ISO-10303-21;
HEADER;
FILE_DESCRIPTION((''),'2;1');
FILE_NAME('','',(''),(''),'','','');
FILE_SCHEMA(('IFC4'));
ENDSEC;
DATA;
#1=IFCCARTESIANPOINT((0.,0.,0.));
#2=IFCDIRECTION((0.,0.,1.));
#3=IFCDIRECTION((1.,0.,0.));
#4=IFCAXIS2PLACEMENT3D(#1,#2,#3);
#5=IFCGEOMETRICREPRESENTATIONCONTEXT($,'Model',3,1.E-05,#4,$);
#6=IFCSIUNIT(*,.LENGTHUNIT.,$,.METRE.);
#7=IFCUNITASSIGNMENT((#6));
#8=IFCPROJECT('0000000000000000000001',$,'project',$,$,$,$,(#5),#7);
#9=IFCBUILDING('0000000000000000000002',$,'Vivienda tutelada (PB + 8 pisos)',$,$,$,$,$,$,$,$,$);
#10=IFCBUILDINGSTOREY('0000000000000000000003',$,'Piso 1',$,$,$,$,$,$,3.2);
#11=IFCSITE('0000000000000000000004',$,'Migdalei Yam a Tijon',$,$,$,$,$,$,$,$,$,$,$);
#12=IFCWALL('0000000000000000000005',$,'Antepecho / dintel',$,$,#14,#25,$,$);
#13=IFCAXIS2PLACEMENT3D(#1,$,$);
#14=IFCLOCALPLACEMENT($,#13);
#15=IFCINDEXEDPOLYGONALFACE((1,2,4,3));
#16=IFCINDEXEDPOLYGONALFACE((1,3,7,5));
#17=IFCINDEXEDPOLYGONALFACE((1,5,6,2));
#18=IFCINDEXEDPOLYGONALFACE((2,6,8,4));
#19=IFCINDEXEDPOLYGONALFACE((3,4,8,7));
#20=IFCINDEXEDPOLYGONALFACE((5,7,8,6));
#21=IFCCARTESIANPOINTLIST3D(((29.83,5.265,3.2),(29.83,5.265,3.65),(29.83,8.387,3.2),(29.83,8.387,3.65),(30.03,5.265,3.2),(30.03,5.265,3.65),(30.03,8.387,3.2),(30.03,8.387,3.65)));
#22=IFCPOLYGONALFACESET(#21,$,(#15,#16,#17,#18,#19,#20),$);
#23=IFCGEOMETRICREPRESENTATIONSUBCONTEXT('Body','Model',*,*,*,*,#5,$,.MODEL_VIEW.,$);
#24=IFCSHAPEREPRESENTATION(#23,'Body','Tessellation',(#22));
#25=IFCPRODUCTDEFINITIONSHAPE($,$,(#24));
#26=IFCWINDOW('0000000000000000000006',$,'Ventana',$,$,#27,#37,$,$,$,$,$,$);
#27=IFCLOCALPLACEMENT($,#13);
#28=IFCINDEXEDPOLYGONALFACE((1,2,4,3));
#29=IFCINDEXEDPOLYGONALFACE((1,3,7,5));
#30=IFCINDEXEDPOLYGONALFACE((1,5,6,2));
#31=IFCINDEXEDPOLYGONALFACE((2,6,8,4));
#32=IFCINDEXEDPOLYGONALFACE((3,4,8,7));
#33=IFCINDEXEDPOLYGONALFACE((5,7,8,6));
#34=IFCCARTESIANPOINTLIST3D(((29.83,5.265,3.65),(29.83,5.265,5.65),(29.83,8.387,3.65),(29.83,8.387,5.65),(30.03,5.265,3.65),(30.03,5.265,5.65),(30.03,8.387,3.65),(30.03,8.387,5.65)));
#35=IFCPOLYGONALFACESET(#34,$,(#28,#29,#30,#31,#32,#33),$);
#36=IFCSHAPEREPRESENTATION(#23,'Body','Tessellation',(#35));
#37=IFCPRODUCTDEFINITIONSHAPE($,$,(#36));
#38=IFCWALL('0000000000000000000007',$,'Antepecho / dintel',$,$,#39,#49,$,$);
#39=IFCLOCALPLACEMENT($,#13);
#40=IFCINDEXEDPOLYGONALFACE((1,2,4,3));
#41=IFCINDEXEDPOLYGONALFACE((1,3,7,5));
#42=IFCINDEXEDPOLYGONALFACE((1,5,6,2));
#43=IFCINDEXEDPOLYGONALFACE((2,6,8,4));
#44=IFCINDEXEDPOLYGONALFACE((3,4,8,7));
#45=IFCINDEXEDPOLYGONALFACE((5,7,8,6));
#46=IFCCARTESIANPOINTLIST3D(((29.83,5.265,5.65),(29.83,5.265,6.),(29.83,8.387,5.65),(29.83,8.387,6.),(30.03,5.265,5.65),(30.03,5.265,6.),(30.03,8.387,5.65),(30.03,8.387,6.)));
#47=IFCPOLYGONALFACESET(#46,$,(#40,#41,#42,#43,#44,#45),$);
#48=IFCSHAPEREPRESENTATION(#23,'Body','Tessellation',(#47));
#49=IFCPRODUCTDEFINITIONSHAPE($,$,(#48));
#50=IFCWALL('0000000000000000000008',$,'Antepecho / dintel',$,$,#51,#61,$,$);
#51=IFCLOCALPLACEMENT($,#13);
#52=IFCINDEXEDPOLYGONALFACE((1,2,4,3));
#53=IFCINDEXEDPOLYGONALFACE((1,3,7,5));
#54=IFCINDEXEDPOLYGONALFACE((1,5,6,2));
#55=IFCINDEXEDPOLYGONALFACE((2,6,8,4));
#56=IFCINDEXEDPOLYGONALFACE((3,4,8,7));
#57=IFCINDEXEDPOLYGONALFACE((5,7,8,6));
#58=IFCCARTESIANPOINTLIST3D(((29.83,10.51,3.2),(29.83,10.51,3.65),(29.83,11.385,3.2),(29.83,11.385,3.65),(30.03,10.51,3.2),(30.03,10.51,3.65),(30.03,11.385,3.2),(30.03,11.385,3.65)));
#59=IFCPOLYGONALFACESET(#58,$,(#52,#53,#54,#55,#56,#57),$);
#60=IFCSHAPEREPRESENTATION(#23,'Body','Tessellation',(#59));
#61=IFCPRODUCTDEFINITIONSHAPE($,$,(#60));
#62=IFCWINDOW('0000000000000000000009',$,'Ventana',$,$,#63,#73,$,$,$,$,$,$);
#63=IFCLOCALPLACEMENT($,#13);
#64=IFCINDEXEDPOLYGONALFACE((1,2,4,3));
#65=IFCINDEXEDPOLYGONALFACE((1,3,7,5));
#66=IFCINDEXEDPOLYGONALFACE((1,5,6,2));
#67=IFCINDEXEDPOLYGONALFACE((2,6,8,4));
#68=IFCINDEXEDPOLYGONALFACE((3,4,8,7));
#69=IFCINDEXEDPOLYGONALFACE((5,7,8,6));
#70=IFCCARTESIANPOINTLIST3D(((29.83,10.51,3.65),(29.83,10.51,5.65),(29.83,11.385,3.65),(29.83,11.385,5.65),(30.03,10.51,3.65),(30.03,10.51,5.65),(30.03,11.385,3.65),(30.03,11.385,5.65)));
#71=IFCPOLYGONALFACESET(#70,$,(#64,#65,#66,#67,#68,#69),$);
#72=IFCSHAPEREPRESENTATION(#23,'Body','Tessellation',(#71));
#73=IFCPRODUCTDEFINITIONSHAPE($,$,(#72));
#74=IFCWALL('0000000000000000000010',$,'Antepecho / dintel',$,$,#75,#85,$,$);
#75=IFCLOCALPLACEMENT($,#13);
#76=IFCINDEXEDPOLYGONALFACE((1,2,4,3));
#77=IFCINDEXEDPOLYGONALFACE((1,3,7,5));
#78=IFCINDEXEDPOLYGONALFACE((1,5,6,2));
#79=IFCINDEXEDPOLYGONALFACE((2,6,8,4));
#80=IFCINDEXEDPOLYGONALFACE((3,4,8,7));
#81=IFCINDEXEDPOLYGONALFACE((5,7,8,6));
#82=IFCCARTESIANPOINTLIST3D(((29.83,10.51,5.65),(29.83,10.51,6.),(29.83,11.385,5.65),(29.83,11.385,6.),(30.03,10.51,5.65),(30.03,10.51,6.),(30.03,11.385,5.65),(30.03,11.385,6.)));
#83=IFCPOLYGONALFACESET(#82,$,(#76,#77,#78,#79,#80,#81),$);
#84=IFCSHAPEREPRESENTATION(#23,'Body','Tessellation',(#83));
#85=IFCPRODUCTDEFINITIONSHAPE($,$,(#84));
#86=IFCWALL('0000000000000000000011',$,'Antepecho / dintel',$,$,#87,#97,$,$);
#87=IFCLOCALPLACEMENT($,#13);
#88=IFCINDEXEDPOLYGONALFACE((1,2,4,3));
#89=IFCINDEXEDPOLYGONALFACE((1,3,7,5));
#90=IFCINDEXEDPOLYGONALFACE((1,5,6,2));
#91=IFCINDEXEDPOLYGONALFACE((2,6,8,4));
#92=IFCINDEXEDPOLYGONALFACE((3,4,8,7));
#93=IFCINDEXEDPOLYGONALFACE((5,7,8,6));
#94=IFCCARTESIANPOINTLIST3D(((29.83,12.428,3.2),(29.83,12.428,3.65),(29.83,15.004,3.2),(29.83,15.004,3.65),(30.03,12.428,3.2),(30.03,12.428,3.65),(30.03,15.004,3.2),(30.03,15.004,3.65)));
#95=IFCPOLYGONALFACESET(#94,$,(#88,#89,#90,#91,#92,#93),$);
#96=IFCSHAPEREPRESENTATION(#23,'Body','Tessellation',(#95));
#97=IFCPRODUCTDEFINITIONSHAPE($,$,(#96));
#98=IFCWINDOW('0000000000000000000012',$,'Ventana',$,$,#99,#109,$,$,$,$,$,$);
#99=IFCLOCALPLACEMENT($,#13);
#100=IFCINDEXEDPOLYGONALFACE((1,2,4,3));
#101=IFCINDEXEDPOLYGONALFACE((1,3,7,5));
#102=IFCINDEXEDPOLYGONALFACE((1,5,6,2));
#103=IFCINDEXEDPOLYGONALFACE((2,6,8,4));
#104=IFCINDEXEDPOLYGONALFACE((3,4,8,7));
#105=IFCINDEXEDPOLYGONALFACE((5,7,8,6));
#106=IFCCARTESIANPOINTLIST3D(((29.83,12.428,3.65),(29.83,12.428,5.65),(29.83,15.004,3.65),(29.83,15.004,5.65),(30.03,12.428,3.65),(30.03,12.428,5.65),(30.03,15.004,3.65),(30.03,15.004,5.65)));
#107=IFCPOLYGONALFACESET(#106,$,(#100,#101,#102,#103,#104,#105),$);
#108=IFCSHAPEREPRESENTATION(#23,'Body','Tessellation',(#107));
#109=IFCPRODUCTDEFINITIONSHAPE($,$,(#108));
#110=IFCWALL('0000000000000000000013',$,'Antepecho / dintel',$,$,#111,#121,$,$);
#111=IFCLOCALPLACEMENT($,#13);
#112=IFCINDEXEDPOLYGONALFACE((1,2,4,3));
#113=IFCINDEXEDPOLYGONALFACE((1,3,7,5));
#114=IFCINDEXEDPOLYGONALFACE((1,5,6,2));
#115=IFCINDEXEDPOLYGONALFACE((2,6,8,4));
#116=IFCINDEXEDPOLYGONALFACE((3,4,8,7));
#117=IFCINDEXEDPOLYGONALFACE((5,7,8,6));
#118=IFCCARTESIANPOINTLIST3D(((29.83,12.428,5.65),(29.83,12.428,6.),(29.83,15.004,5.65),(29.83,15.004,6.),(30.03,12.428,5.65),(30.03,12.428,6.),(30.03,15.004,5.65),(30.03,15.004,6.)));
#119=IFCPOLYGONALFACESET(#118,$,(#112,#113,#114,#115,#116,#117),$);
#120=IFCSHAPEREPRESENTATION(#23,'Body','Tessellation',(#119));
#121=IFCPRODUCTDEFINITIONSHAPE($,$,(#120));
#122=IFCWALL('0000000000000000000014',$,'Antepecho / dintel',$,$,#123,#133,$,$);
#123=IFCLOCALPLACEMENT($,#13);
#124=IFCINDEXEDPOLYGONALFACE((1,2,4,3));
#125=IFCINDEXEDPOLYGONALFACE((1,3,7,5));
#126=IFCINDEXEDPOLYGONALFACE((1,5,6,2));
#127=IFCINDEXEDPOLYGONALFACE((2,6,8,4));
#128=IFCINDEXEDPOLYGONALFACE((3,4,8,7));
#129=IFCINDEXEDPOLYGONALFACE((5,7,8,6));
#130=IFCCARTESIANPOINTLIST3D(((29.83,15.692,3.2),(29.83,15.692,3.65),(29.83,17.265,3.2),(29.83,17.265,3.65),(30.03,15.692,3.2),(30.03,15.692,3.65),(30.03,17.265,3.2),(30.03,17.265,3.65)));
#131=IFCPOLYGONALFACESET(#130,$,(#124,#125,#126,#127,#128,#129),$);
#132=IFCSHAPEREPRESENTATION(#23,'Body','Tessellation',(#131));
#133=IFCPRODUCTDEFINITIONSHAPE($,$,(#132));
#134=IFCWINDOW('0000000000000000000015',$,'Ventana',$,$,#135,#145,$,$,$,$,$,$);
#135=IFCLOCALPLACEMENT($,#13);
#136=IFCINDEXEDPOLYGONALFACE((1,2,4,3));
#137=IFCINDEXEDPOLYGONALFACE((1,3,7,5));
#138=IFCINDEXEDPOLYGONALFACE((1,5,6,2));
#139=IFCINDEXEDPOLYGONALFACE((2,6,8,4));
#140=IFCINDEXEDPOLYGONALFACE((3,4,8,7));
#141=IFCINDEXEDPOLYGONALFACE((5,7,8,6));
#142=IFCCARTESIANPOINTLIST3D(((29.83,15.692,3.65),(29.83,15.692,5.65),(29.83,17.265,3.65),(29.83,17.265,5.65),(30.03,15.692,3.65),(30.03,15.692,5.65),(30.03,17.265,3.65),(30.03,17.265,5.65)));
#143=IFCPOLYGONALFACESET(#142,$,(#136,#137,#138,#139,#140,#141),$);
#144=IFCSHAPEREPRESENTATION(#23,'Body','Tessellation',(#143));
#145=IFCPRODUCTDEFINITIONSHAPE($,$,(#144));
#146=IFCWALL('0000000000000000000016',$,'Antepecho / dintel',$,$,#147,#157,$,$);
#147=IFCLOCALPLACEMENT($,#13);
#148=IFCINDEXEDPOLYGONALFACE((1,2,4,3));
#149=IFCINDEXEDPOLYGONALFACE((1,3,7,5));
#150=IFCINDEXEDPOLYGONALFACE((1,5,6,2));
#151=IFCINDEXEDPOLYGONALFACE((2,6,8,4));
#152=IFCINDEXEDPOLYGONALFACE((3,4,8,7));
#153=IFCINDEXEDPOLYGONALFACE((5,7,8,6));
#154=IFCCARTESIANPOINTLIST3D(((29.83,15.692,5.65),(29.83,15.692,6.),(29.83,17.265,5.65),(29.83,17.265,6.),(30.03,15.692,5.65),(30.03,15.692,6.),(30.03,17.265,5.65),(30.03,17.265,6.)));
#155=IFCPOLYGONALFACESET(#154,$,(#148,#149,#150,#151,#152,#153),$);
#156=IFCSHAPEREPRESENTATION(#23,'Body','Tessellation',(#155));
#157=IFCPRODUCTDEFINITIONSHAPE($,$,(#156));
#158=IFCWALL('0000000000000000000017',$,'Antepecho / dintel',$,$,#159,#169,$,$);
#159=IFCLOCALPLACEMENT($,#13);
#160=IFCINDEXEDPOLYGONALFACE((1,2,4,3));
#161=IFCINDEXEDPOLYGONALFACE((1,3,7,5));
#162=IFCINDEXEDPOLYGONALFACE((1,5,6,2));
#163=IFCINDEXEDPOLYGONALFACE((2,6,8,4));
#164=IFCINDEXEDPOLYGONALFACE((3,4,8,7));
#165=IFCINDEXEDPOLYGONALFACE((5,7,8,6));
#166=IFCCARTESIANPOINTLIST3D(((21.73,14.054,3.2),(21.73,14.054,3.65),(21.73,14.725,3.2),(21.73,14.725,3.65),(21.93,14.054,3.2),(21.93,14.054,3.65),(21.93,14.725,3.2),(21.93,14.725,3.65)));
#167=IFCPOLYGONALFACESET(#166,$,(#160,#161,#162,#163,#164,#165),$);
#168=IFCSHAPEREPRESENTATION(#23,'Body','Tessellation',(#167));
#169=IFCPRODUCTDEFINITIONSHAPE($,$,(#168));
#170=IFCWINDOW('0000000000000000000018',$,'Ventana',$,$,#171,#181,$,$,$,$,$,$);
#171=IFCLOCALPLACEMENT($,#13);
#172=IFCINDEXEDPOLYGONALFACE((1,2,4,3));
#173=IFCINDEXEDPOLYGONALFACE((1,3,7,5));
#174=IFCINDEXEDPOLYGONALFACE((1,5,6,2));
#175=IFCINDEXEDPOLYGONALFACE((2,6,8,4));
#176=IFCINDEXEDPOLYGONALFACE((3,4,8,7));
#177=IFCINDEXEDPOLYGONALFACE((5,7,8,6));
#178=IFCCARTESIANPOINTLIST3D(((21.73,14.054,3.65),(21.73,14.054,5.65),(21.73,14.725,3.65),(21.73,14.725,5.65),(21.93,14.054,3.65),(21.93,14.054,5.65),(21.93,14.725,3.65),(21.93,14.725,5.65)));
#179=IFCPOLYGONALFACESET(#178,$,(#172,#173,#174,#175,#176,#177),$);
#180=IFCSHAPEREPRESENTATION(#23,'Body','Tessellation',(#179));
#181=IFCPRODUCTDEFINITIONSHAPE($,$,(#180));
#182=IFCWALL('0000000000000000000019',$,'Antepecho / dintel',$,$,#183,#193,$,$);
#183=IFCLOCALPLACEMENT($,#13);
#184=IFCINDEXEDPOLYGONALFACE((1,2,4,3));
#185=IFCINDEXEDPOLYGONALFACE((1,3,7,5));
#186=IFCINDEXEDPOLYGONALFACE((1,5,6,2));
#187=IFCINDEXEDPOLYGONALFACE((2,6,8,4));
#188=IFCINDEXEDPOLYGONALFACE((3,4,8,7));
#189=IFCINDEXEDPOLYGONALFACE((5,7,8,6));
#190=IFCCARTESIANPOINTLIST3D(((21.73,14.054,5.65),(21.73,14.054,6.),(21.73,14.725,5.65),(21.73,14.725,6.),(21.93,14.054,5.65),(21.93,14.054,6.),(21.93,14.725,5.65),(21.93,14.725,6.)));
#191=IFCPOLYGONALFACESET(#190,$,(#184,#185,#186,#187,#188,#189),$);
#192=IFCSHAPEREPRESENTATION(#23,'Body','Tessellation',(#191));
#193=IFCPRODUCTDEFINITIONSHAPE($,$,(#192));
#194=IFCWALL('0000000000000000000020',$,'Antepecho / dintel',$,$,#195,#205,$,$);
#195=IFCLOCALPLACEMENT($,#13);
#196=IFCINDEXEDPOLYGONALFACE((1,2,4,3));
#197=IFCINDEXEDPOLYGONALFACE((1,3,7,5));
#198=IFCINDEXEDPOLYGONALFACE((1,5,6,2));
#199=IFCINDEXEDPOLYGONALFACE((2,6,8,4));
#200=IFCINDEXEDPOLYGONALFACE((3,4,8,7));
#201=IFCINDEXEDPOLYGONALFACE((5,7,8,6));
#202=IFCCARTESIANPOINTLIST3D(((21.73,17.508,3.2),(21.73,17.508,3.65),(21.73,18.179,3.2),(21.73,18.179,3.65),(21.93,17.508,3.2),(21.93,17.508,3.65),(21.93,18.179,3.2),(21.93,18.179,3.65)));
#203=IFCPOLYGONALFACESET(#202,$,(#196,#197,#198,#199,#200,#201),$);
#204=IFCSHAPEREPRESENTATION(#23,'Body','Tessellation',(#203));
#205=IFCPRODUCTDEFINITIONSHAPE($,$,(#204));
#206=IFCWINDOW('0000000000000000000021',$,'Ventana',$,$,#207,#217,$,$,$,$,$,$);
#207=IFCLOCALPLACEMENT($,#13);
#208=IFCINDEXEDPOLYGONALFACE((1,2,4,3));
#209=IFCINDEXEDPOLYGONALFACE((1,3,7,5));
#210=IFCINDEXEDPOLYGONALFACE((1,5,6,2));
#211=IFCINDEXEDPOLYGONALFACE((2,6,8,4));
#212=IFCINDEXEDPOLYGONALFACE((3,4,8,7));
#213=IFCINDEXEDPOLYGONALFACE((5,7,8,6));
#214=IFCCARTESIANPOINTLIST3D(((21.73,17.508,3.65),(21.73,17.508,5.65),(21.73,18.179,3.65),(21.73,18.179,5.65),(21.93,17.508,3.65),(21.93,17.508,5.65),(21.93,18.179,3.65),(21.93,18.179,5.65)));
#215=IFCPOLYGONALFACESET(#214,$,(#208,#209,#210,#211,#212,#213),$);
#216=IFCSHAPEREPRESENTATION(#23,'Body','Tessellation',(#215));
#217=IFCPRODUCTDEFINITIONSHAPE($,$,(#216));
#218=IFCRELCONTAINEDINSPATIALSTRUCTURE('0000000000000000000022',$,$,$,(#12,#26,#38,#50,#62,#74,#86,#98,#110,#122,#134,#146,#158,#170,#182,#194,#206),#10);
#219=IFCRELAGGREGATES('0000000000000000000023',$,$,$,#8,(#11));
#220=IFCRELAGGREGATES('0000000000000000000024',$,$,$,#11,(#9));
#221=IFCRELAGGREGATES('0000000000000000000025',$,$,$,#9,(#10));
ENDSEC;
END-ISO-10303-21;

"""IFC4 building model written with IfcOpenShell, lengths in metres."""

from ifc_helpers import new_model, si_unit, frame, origin_with_axes, context, subcontext, project, spatial, line, indexed_curve, outline, extrude, element, save


model = new_model("IFC4")

# Units and contexts
model_context = context("Model", 3, precision=1e-05, world=origin_with_axes())
body_context = subcontext(model_context, "Body", "Model", "MODEL_VIEW")
ifc_project = project(units=[si_unit("LENGTHUNIT", "METRE")], contexts=[model_context])

# Site, building, storey
site = spatial("IfcSite", under=ifc_project, Name="Migdalei Yam a Tijon")
building = spatial("IfcBuilding", under=site, Name="Vivienda tutelada (PB + 8 pisos)")
storey = spatial("IfcBuildingStorey", under=building, Name="Piso 1", Elevation=3.2)

# Wall
element("IfcWall", 1, inside=storey, Name="Antepecho / dintel", context=body_context, shape_type="SweptSolid", body=[
    extrude(outline(indexed_curve([(0.0, 0.0), (0.2, 0.0), (0.2, 3.122), (0.0, 3.122)], segments=[line(1, 2, 3, 4, 1)])), frame((29.83, 5.265, 3.2), z_axis=(0.0, 0.0, 1.0), x_axis=(1.0, 0.0, 0.0)), (0.0, 0.0, 1.0), 0.45),
])

# Window
element("IfcWindow", 2, inside=storey, Name="Ventana", context=body_context, shape_type="SweptSolid", body=[
    extrude(outline(indexed_curve([(0.0, 0.0), (0.2, 0.0), (0.2, 3.122), (0.0, 3.122)], segments=[line(1, 2, 3, 4, 1)])), frame((29.83, 5.265, 3.65), z_axis=(0.0, 0.0, 1.0), x_axis=(1.0, 0.0, 0.0)), (0.0, 0.0, 1.0), 2.0),
])

# Walls
element("IfcWall", 3, inside=storey, Name="Antepecho / dintel", context=body_context, shape_type="SweptSolid", body=[
    extrude(outline(indexed_curve([(0.0, 0.0), (0.2, 0.0), (0.2, 3.122), (0.0, 3.122)], segments=[line(1, 2, 3, 4, 1)])), frame((29.83, 5.265, 5.65), z_axis=(0.0, 0.0, 1.0), x_axis=(1.0, 0.0, 0.0)), (0.0, 0.0, 1.0), 0.35),
])
element("IfcWall", 4, inside=storey, Name="Antepecho / dintel", context=body_context, shape_type="SweptSolid", body=[
    extrude(outline(indexed_curve([(0.0, 0.0), (0.2, 0.0), (0.2, 0.875), (0.0, 0.875)], segments=[line(1, 2, 3, 4, 1)])), frame((29.83, 10.51, 3.2), z_axis=(0.0, 0.0, 1.0), x_axis=(1.0, 0.0, 0.0)), (0.0, 0.0, 1.0), 0.45),
])

# Window
element("IfcWindow", 5, inside=storey, Name="Ventana", context=body_context, shape_type="SweptSolid", body=[
    extrude(outline(indexed_curve([(0.0, 0.0), (0.2, 0.0), (0.2, 0.875), (0.0, 0.875)], segments=[line(1, 2, 3, 4, 1)])), frame((29.83, 10.51, 3.65), z_axis=(0.0, 0.0, 1.0), x_axis=(1.0, 0.0, 0.0)), (0.0, 0.0, 1.0), 2.0),
])

# Walls
element("IfcWall", 6, inside=storey, Name="Antepecho / dintel", context=body_context, shape_type="SweptSolid", body=[
    extrude(outline(indexed_curve([(0.0, 0.0), (0.2, 0.0), (0.2, 0.875), (0.0, 0.875)], segments=[line(1, 2, 3, 4, 1)])), frame((29.83, 10.51, 5.65), z_axis=(0.0, 0.0, 1.0), x_axis=(1.0, 0.0, 0.0)), (0.0, 0.0, 1.0), 0.35),
])
element("IfcWall", 7, inside=storey, Name="Antepecho / dintel", context=body_context, shape_type="SweptSolid", body=[
    extrude(outline(indexed_curve([(0.0, 0.0), (0.2, 0.0), (0.2, 2.576), (0.0, 2.576)], segments=[line(1, 2, 3, 4, 1)])), frame((29.83, 12.428, 3.2), z_axis=(0.0, 0.0, 1.0), x_axis=(1.0, 0.0, 0.0)), (0.0, 0.0, 1.0), 0.45),
])

# Window
element("IfcWindow", 8, inside=storey, Name="Ventana", context=body_context, shape_type="SweptSolid", body=[
    extrude(outline(indexed_curve([(0.0, 0.0), (0.2, 0.0), (0.2, 2.576), (0.0, 2.576)], segments=[line(1, 2, 3, 4, 1)])), frame((29.83, 12.428, 3.65), z_axis=(0.0, 0.0, 1.0), x_axis=(1.0, 0.0, 0.0)), (0.0, 0.0, 1.0), 2.0),
])

# Walls
element("IfcWall", 9, inside=storey, Name="Antepecho / dintel", context=body_context, shape_type="SweptSolid", body=[
    extrude(outline(indexed_curve([(0.0, 0.0), (0.2, 0.0), (0.2, 2.576), (0.0, 2.576)], segments=[line(1, 2, 3, 4, 1)])), frame((29.83, 12.428, 5.65), z_axis=(0.0, 0.0, 1.0), x_axis=(1.0, 0.0, 0.0)), (0.0, 0.0, 1.0), 0.35),
])
element("IfcWall", 10, inside=storey, Name="Antepecho / dintel", context=body_context, shape_type="SweptSolid", body=[
    extrude(outline(indexed_curve([(0.0, 0.0), (0.2, 0.0), (0.2, 1.573), (0.0, 1.573)], segments=[line(1, 2, 3, 4, 1)])), frame((29.83, 15.692, 3.2), z_axis=(0.0, 0.0, 1.0), x_axis=(1.0, 0.0, 0.0)), (0.0, 0.0, 1.0), 0.45),
])

# Window
element("IfcWindow", 11, inside=storey, Name="Ventana", context=body_context, shape_type="SweptSolid", body=[
    extrude(outline(indexed_curve([(0.0, 0.0), (0.2, 0.0), (0.2, 1.573), (0.0, 1.573)], segments=[line(1, 2, 3, 4, 1)])), frame((29.83, 15.692, 3.65), z_axis=(0.0, 0.0, 1.0), x_axis=(1.0, 0.0, 0.0)), (0.0, 0.0, 1.0), 2.0),
])

# Walls
element("IfcWall", 12, inside=storey, Name="Antepecho / dintel", context=body_context, shape_type="SweptSolid", body=[
    extrude(outline(indexed_curve([(0.0, 0.0), (0.2, 0.0), (0.2, 1.573), (0.0, 1.573)], segments=[line(1, 2, 3, 4, 1)])), frame((29.83, 15.692, 5.65), z_axis=(0.0, 0.0, 1.0), x_axis=(1.0, 0.0, 0.0)), (0.0, 0.0, 1.0), 0.35),
])
element("IfcWall", 13, inside=storey, Name="Antepecho / dintel", context=body_context, shape_type="SweptSolid", body=[
    extrude(outline(indexed_curve([(0.0, 0.0), (0.2, 0.0), (0.2, 0.671), (0.0, 0.671)], segments=[line(1, 2, 3, 4, 1)])), frame((21.73, 14.054, 3.2), z_axis=(0.0, 0.0, 1.0), x_axis=(1.0, 0.0, 0.0)), (0.0, 0.0, 1.0), 0.45),
])

# Window
element("IfcWindow", 14, inside=storey, Name="Ventana", context=body_context, shape_type="SweptSolid", body=[
    extrude(outline(indexed_curve([(0.0, 0.0), (0.2, 0.0), (0.2, 0.671), (0.0, 0.671)], segments=[line(1, 2, 3, 4, 1)])), frame((21.73, 14.054, 3.65), z_axis=(0.0, 0.0, 1.0), x_axis=(1.0, 0.0, 0.0)), (0.0, 0.0, 1.0), 2.0),
])

# Walls
element("IfcWall", 15, inside=storey, Name="Antepecho / dintel", context=body_context, shape_type="SweptSolid", body=[
    extrude(outline(indexed_curve([(0.0, 0.0), (0.2, 0.0), (0.2, 0.671), (0.0, 0.671)], segments=[line(1, 2, 3, 4, 1)])), frame((21.73, 14.054, 5.65), z_axis=(0.0, 0.0, 1.0), x_axis=(1.0, 0.0, 0.0)), (0.0, 0.0, 1.0), 0.35),
])
element("IfcWall", 16, inside=storey, Name="Antepecho / dintel", context=body_context, shape_type="SweptSolid", body=[
    extrude(outline(indexed_curve([(0.0, 0.0), (0.2, 0.0), (0.2, 0.671), (0.0, 0.671)], segments=[line(1, 2, 3, 4, 1)])), frame((21.73, 17.508, 3.2), z_axis=(0.0, 0.0, 1.0), x_axis=(1.0, 0.0, 0.0)), (0.0, 0.0, 1.0), 0.45),
])

# Window
element("IfcWindow", 17, inside=storey, Name="Ventana", context=body_context, shape_type="SweptSolid", body=[
    extrude(outline(indexed_curve([(0.0, 0.0), (0.2, 0.0), (0.2, 0.671), (0.0, 0.671)], segments=[line(1, 2, 3, 4, 1)])), frame((21.73, 17.508, 3.65), z_axis=(0.0, 0.0, 1.0), x_axis=(1.0, 0.0, 0.0)), (0.0, 0.0, 1.0), 2.0),
])

save(model, "model.ifc")
